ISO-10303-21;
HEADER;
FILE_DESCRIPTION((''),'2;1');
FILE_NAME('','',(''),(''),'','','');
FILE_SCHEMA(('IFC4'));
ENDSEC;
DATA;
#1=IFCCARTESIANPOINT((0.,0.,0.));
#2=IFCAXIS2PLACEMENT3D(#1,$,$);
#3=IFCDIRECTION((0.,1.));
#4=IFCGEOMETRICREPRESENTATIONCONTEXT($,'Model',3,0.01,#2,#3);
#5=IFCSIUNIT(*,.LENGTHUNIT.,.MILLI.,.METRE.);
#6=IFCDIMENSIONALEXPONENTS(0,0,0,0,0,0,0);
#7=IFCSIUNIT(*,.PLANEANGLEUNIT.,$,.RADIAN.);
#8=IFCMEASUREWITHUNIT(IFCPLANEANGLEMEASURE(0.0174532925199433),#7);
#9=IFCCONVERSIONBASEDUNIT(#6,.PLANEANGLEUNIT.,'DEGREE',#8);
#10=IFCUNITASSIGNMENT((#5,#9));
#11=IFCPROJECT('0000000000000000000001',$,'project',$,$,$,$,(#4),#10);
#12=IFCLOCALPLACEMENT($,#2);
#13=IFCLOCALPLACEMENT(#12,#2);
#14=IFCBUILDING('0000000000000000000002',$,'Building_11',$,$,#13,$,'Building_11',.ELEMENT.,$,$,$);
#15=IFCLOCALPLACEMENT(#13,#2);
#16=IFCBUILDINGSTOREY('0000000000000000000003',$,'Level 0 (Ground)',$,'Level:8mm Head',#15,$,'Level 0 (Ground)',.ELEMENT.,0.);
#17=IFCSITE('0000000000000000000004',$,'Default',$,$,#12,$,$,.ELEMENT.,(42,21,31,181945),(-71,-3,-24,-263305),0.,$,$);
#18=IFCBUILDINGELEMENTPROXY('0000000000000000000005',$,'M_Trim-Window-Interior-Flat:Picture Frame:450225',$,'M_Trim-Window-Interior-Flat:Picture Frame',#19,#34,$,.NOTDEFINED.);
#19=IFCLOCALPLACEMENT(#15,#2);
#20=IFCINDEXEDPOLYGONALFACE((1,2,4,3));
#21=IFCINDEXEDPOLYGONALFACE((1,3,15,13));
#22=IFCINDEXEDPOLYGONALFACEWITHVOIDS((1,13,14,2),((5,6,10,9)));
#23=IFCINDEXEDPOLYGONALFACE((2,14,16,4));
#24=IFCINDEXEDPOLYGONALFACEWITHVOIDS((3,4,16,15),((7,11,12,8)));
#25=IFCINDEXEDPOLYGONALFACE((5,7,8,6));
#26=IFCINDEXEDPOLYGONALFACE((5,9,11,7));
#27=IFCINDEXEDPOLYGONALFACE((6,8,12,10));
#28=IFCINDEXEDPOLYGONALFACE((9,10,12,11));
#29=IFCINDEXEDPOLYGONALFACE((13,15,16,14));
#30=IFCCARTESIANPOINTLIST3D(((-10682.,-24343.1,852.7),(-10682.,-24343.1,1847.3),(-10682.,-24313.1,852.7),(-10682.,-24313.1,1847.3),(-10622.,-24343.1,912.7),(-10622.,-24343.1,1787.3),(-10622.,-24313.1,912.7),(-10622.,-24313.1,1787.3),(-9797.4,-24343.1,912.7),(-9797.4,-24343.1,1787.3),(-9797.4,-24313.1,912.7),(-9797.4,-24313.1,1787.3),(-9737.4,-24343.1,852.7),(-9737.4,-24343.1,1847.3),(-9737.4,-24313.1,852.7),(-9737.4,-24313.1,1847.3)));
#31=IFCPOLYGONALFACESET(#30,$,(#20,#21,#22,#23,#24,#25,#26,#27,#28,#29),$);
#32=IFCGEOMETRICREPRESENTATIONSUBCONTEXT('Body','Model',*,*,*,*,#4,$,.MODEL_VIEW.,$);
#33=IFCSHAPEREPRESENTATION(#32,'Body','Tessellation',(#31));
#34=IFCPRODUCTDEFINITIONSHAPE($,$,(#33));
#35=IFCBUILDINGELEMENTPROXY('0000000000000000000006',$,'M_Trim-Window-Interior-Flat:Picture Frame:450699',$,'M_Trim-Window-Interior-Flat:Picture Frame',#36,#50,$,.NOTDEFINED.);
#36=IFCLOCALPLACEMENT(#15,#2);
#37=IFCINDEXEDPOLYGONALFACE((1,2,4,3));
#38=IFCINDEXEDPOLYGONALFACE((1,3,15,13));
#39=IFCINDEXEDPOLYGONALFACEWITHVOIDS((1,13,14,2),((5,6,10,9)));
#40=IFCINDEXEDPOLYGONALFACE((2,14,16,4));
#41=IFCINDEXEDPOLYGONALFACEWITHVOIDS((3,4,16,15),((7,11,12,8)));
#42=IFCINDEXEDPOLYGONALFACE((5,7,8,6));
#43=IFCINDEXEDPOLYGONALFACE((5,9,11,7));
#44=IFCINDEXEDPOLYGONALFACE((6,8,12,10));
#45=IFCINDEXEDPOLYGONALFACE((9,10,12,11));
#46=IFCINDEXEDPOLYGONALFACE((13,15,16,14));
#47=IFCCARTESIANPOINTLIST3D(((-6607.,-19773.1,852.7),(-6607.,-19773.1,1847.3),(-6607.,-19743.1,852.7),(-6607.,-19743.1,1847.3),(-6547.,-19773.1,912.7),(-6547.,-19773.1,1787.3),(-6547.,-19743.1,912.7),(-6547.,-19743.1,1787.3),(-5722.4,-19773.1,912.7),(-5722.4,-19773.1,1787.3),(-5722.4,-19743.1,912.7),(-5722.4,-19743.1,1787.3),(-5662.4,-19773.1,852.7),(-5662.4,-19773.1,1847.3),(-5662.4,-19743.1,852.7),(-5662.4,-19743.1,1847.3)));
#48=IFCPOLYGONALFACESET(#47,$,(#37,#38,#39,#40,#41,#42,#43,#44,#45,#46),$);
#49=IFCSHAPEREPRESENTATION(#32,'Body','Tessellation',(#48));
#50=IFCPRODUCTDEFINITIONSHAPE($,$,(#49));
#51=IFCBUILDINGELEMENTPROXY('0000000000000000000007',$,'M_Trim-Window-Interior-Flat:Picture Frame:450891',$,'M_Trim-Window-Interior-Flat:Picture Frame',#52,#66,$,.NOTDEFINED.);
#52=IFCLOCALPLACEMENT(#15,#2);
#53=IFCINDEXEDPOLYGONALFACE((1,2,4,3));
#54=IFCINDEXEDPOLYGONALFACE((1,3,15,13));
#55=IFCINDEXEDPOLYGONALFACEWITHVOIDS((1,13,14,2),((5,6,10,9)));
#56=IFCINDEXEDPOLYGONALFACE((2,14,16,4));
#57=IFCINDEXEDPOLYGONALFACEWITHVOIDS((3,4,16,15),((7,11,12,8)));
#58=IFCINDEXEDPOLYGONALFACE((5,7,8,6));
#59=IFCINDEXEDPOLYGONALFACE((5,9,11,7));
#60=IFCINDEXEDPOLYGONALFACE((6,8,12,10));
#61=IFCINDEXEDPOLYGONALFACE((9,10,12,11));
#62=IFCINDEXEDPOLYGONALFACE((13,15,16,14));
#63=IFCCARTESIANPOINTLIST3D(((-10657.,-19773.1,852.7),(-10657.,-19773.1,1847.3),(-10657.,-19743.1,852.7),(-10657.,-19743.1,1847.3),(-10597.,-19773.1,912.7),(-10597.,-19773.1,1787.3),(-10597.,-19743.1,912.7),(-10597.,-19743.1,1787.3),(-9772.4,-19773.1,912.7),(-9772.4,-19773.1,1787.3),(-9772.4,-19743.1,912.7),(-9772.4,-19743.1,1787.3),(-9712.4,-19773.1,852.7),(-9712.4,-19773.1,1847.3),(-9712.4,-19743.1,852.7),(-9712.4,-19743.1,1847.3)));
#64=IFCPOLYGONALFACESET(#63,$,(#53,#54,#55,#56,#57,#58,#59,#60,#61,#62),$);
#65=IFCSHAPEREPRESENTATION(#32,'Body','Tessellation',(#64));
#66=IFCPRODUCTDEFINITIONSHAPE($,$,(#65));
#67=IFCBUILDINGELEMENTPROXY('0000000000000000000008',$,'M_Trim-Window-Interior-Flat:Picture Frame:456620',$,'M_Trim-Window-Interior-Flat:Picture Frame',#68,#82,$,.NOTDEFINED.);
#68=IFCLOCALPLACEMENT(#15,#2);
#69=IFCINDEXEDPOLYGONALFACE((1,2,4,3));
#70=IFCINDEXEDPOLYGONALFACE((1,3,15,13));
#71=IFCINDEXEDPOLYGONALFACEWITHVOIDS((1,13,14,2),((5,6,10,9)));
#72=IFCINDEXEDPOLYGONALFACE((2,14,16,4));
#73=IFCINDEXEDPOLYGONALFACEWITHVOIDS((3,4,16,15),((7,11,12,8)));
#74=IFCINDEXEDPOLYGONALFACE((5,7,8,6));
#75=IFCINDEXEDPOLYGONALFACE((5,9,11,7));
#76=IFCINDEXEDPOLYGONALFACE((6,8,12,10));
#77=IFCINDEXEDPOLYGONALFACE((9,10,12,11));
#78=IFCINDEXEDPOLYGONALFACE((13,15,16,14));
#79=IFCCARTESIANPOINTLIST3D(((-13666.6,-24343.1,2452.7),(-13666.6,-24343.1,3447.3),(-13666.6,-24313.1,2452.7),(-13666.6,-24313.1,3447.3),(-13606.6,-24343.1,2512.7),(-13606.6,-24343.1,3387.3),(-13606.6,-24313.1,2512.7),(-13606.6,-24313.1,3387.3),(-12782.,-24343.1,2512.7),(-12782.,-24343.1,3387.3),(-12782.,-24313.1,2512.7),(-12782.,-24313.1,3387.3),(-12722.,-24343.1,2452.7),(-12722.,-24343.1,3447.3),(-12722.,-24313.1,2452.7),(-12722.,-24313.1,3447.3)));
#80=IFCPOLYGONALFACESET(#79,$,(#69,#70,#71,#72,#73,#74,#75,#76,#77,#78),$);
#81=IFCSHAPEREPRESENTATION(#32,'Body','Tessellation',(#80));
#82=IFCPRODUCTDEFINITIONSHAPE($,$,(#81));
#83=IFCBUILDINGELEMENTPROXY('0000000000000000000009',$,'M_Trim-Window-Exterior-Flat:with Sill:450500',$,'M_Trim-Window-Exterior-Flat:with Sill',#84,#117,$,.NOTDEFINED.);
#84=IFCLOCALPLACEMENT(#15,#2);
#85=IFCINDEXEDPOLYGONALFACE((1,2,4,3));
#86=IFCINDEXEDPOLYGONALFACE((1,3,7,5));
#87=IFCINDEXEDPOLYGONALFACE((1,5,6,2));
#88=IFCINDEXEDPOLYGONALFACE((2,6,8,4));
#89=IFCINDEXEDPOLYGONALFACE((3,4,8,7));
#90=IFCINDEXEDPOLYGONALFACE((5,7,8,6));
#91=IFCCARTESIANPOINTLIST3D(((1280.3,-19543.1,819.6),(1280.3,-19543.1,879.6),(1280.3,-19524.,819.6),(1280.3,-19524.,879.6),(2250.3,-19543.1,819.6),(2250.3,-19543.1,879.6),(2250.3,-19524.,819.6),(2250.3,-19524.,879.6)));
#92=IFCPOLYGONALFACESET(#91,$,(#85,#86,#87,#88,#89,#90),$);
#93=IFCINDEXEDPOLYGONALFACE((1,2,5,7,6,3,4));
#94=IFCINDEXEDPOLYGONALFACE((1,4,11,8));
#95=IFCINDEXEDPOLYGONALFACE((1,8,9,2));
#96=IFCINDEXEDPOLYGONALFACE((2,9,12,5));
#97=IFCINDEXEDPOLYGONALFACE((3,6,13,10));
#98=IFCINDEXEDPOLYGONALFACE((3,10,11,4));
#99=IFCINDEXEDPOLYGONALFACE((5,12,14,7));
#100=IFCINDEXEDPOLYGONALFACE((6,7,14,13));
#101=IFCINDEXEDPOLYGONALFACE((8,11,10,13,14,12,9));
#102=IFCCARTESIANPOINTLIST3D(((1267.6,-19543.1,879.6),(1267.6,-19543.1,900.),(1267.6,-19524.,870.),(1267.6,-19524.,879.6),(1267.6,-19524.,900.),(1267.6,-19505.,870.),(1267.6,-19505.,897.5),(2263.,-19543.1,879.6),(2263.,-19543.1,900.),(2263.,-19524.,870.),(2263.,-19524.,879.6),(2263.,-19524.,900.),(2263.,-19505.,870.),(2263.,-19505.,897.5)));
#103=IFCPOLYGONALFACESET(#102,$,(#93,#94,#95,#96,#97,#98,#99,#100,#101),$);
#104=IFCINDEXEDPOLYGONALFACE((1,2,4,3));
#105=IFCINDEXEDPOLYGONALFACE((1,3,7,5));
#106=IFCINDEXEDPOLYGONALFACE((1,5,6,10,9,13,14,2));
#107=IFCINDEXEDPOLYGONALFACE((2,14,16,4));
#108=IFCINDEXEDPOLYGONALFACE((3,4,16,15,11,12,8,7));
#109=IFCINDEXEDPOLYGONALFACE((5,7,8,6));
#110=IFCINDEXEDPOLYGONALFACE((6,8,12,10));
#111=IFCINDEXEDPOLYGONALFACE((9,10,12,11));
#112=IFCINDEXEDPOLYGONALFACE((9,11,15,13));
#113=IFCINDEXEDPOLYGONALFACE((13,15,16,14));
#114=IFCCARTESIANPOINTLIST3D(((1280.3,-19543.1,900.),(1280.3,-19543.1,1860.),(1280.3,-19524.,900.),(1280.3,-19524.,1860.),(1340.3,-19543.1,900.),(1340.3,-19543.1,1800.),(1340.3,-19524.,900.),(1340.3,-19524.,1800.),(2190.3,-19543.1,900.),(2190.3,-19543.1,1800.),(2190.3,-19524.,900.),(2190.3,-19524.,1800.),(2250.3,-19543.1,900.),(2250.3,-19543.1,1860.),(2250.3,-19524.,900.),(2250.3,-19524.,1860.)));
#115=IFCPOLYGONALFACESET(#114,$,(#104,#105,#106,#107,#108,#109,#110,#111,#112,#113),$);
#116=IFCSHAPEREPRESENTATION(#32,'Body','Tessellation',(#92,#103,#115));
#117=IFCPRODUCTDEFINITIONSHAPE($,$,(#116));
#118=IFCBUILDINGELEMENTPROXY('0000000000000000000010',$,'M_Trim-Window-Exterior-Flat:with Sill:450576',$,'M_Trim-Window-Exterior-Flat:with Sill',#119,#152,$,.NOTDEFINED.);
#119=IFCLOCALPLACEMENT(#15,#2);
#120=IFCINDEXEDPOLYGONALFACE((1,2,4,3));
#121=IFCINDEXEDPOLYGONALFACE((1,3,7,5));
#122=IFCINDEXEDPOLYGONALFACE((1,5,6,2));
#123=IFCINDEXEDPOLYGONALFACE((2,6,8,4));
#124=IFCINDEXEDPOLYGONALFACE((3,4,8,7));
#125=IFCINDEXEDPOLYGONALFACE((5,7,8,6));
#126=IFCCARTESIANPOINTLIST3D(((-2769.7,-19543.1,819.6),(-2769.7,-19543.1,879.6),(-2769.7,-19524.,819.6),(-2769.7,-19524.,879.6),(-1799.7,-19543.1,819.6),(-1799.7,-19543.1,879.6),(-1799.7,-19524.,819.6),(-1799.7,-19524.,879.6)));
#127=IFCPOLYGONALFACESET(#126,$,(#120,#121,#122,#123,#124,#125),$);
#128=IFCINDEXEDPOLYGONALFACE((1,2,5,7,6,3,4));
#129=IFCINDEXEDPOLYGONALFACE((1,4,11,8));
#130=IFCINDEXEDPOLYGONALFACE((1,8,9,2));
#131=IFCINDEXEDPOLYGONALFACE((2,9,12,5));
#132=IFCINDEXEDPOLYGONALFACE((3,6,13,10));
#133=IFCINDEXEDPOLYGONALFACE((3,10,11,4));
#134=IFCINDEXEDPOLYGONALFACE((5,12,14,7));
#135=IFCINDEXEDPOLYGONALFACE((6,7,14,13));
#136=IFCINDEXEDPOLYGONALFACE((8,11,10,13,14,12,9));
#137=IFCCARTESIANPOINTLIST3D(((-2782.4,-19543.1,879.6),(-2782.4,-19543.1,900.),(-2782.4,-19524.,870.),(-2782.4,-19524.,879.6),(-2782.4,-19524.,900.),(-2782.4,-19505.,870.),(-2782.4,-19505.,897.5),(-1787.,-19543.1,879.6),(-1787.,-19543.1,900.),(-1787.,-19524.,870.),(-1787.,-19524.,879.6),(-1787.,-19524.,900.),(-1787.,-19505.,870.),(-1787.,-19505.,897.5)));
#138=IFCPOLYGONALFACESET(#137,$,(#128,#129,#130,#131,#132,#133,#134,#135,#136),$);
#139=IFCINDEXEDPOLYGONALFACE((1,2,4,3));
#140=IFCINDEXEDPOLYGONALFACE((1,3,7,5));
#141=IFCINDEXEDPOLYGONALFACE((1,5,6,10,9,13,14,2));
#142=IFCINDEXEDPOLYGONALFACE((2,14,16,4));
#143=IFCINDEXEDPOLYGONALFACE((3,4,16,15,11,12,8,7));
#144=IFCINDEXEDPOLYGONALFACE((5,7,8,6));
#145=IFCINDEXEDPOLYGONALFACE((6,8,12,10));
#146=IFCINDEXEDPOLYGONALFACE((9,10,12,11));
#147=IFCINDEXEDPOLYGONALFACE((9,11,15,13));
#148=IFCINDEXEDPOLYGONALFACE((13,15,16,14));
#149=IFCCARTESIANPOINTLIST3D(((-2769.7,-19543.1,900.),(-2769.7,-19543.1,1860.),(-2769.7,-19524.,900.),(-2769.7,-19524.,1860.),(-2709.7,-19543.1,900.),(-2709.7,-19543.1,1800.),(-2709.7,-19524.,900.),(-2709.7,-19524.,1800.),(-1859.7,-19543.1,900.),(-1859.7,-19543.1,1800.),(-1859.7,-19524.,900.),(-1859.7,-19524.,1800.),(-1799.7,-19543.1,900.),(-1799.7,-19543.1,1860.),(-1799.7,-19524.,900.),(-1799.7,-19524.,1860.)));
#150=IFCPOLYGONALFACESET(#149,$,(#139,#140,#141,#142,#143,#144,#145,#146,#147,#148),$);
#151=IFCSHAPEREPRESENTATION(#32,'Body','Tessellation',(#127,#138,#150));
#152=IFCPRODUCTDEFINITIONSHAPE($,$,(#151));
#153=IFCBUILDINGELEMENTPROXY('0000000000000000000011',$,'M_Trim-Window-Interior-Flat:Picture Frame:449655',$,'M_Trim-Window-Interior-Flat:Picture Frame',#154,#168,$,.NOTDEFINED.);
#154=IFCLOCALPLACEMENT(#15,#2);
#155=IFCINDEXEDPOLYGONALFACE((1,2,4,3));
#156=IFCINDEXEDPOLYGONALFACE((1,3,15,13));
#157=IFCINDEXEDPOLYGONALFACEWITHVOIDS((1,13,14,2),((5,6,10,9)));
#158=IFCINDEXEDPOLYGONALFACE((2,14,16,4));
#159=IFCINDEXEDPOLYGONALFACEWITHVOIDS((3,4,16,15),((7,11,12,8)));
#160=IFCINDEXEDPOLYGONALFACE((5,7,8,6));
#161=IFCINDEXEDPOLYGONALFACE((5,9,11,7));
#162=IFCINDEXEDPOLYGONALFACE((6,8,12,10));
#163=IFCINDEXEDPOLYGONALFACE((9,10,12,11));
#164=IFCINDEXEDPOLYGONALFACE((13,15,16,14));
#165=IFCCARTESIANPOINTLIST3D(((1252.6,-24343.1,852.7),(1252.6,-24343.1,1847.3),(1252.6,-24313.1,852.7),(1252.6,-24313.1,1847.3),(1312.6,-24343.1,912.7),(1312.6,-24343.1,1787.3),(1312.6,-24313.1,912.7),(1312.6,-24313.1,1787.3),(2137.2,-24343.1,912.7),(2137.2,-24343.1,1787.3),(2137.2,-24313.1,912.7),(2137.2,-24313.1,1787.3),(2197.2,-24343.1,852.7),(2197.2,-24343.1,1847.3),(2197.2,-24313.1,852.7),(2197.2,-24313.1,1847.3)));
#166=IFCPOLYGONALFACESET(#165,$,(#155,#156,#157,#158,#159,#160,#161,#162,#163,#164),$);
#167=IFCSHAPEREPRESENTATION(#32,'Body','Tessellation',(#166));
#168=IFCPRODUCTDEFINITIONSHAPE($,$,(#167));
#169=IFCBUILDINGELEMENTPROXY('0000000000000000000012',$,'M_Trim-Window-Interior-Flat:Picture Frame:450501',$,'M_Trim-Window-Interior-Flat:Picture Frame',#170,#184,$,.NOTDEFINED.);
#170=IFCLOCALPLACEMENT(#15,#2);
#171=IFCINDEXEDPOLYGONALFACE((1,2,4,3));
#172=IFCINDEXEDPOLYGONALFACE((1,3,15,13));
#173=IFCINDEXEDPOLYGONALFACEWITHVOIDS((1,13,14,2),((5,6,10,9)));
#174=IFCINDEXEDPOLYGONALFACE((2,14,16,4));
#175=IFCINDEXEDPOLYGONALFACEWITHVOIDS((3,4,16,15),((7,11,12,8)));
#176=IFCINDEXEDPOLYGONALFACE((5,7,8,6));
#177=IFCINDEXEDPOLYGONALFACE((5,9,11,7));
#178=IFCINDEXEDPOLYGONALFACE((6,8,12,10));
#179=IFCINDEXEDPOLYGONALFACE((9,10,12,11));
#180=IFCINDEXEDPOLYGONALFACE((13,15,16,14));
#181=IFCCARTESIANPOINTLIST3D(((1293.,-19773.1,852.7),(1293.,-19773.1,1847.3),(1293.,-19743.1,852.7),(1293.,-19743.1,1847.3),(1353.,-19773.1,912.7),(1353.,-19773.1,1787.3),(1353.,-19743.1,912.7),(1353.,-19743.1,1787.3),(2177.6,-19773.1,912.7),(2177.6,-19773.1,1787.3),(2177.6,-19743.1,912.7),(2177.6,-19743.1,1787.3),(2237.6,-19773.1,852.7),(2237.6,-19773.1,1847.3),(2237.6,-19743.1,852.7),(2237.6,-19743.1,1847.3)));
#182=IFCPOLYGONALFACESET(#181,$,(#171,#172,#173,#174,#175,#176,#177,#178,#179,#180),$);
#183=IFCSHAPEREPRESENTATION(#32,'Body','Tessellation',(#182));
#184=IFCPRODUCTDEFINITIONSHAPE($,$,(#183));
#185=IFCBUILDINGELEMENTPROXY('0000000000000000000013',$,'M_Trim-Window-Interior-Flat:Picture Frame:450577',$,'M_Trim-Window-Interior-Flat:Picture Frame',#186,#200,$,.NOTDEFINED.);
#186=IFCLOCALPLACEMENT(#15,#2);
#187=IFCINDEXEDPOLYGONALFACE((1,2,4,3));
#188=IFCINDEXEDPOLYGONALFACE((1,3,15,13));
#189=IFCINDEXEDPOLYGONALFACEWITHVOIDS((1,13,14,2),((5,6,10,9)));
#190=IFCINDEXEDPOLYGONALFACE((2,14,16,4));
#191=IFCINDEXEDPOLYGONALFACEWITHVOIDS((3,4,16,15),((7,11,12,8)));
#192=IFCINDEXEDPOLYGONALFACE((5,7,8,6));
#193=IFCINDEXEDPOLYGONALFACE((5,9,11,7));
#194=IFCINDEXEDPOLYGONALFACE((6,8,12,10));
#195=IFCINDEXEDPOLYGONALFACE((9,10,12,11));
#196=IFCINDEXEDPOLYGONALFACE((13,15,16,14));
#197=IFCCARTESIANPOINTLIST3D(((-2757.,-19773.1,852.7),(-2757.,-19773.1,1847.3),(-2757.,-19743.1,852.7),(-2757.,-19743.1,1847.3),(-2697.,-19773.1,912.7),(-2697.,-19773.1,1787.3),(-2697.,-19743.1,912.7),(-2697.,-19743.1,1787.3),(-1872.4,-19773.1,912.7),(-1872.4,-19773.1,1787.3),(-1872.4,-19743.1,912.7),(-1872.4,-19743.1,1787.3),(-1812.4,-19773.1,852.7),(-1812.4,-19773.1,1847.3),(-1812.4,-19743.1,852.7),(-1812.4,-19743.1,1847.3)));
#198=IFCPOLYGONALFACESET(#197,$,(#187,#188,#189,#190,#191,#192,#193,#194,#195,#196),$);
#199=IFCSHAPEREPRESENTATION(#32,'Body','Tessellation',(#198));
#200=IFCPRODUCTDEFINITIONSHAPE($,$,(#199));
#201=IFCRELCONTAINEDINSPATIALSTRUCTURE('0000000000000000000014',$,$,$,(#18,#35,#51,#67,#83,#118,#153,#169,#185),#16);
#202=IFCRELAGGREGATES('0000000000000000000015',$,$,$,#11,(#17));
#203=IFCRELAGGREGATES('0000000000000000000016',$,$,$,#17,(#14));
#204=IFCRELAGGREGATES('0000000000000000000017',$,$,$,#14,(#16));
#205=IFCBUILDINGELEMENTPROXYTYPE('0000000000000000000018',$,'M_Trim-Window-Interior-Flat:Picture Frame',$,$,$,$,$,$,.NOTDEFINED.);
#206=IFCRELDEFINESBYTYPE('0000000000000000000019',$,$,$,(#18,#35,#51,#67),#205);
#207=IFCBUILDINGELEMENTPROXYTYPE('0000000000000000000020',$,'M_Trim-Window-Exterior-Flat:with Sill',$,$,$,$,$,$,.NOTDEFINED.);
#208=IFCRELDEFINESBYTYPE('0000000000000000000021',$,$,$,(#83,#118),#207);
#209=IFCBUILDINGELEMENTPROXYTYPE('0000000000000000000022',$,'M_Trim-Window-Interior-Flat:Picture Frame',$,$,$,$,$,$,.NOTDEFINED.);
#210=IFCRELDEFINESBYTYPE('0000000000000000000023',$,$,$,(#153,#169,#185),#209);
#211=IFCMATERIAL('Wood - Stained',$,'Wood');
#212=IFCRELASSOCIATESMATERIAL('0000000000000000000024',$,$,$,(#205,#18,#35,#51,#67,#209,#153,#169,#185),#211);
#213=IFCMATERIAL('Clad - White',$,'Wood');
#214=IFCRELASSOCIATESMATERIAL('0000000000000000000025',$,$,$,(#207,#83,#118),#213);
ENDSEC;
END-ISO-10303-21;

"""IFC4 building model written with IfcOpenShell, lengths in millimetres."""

from ifc_helpers import new_model, entity, si_unit, converted_unit, direction, frame, origin, place, context, subcontext, project, spatial, indexed_curve, outline, extrude, source, transform, mapped, material, type_object, type_shapes, element, save


model = new_model("IFC4")

# Units and contexts
model_context = context("Model", 3, precision=0.01, world=origin(), true_north=direction((0.0, 1.0)))
body_context = subcontext(model_context, "Body", "Model", "MODEL_VIEW")
ifc_project = project(units=[si_unit("LENGTHUNIT", "METRE", prefix="MILLI"), converted_unit("PLANEANGLEUNIT", "DEGREE", entity("IfcPlaneAngleMeasure", 0.0174532925199433), si_unit("PLANEANGLEUNIT", "RADIAN"), dimensions=[0, 0, 0, 0, 0, 0, 0])], contexts=[model_context])

# Site, building, storey
site_placement = place(None, origin())
site = spatial("IfcSite", under=ifc_project, at=site_placement, Name="Default", CompositionType="ELEMENT", RefLatitude=(42, 21, 31, 181945), RefLongitude=(-71, -3, -24, -263305), RefElevation=0.0)
building_placement = place(site_placement, origin())
building = spatial("IfcBuilding", under=site, at=building_placement, Name="Building_11", LongName="Building_11", CompositionType="ELEMENT")
storey_placement = place(building_placement, origin())
storey = spatial("IfcBuildingStorey", under=building, at=storey_placement, Name="Level 0 (Ground)", ObjectType="Level:8mm Head", LongName="Level 0 (Ground)", CompositionType="ELEMENT", Elevation=0.0)

# Building element proxies
ifc_material_1 = material(Name="Clad - White", Category="Wood")
ifc_material_2 = material(Name="Wood - Stained", Category="Wood")
building_element_proxy_type_1 = type_object("IfcBuildingElementProxyType", Name="M_Trim-Window-Interior-Flat:Picture Frame", PredefinedType="NOTDEFINED", material=ifc_material_2)
shared_shape_1 = source(origin(), body_context, "Body", "SweptSolid", [
    extrude(outline(indexed_curve([(-472.3, -497.3), (472.3, -497.3), (472.3, 497.3), (-472.3, 497.3), (-472.3, -497.3)], self_intersect=False), holes=[indexed_curve([(-412.3, -437.3), (-412.3, 437.3), (412.3, 437.3), (412.3, -437.3), (-412.3, -437.3)], self_intersect=False)]), frame((0.0, -450.0, 0.0), z_axis=(0.0, 0.0, 1.0), x_axis=(-1.0, 0.0, 0.0)), (0.0, 0.0, 1.0), 30.0),
])
type_shapes(building_element_proxy_type_1, [shared_shape_1])
for number, where, z_axis, x_axis, name in (
    (1, (-10209.7, -24343.1, 1800.0), (0.0, 1.0, 0.0), (-1.0, 0.0, 0.0), "M_Trim-Window-Interior-Flat:Picture Frame:450225"),
    (2, (-6134.7, -19743.1, 1800.0), (0.0, -1.0, 0.0), (1.0, 0.0, 0.0), "M_Trim-Window-Interior-Flat:Picture Frame:450699"),
    (3, (-10184.7, -19743.1, 1800.0), (0.0, -1.0, 0.0), (1.0, 0.0, 0.0), "M_Trim-Window-Interior-Flat:Picture Frame:450891"),
    (4, (-13194.3, -24343.1, 3400.0), (0.0, 1.0, 0.0), (-1.0, 0.0, 0.0), "M_Trim-Window-Interior-Flat:Picture Frame:456620"),
):
    element("IfcBuildingElementProxy", number, at=place(storey_placement, frame(where, z_axis=z_axis, x_axis=x_axis)), inside=storey, type_object=building_element_proxy_type_1, material=ifc_material_2, Name=name, ObjectType="M_Trim-Window-Interior-Flat:Picture Frame", PredefinedType="NOTDEFINED", context=body_context, shape_type="MappedRepresentation", body=[
        mapped(shared_shape_1, transform((0.0, 0.0, 0.0), scale=1.0)),
    ])
building_element_proxy_type_2 = type_object("IfcBuildingElementProxyType", Name="M_Trim-Window-Exterior-Flat:with Sill", PredefinedType="NOTDEFINED", material=ifc_material_1)
shared_shape_2 = source(origin(), body_context, "Body", "SweptSolid", [
    extrude(outline(indexed_curve([(-30.0, -485.0), (30.0, -485.0), (30.0, 485.0), (-30.0, 485.0), (-30.0, -485.0)], self_intersect=False)), frame((0.0, 950.4, 0.0), z_axis=(0.0, 0.0, 1.0), x_axis=(0.0, 1.0, 0.0)), (0.0, 0.0, 1.0), 19.1),
    extrude(outline(indexed_curve([(-15.2, -19.0), (12.3, -19.0), (14.8, 0.0), (14.8, 19.0), (-5.7, 19.0), (-5.7, 0.0), (-15.2, 0.0), (-15.2, -19.0)], self_intersect=False)), frame((-497.7, 914.8, 19.0), z_axis=(1.0, 0.0, 0.0), x_axis=(0.0, -1.0, 0.0)), (0.0, 0.0, 1.0), 995.4),
    extrude(outline(indexed_curve([(-485.0, -495.0), (485.0, -495.0), (485.0, 465.0), (425.0, 465.0), (425.0, -435.0), (-425.0, -435.0), (-425.0, 465.0), (-485.0, 465.0), (-485.0, -495.0)], self_intersect=False)), frame((0.0, 435.0, 0.0)), (0.0, 0.0, 1.0), 19.1),
])
type_shapes(building_element_proxy_type_2, [shared_shape_2])
for number, where, z_axis, x_axis, name in (
    (5, (1765.3, -19543.1, 1800.0), (0.0, 1.0, 0.0), (1.0, 0.0, 0.0), "M_Trim-Window-Exterior-Flat:with Sill:450500"),
    (6, (-2284.7, -19543.1, 1800.0), (0.0, 1.0, 0.0), (1.0, 0.0, 0.0), "M_Trim-Window-Exterior-Flat:with Sill:450576"),
):
    element("IfcBuildingElementProxy", number, at=place(storey_placement, frame(where, z_axis=z_axis, x_axis=x_axis)), inside=storey, type_object=building_element_proxy_type_2, material=ifc_material_1, Name=name, ObjectType="M_Trim-Window-Exterior-Flat:with Sill", PredefinedType="NOTDEFINED", context=body_context, shape_type="MappedRepresentation", body=[
        mapped(shared_shape_2, transform((0.0, 0.0, 0.0), scale=1.0)),
    ])
building_element_proxy_type_3 = type_object("IfcBuildingElementProxyType", Name="M_Trim-Window-Interior-Flat:Picture Frame", PredefinedType="NOTDEFINED", material=ifc_material_2)
shared_shape_3 = source(origin(), body_context, "Body", "SweptSolid", [
    extrude(outline(indexed_curve([(-497.3, -472.3), (497.3, -472.3), (497.3, 472.3), (-497.3, 472.3), (-497.3, -472.3)], self_intersect=False), holes=[indexed_curve([(-437.3, -412.3), (-437.3, 412.3), (437.3, 412.3), (437.3, -412.3), (-437.3, -412.3)], self_intersect=False)]), frame((0.0, 450.0, 0.0), z_axis=(0.0, 0.0, 1.0), x_axis=(0.0, 1.0, 0.0)), (0.0, 0.0, 1.0), 30.0),
])
type_shapes(building_element_proxy_type_3, [shared_shape_3])
for number, where, z_axis, x_axis, name in (
    (7, (1724.9, -24343.1, 1800.0), (0.0, 1.0, 0.0), (1.0, 0.0, 0.0), "M_Trim-Window-Interior-Flat:Picture Frame:449655"),
    (8, (1765.3, -19743.1, 1800.0), (0.0, -1.0, 0.0), (-1.0, 0.0, 0.0), "M_Trim-Window-Interior-Flat:Picture Frame:450501"),
    (9, (-2284.7, -19743.1, 1800.0), (0.0, -1.0, 0.0), (-1.0, 0.0, 0.0), "M_Trim-Window-Interior-Flat:Picture Frame:450577"),
):
    element("IfcBuildingElementProxy", number, at=place(storey_placement, frame(where, z_axis=z_axis, x_axis=x_axis)), inside=storey, type_object=building_element_proxy_type_3, material=ifc_material_2, Name=name, ObjectType="M_Trim-Window-Interior-Flat:Picture Frame", PredefinedType="NOTDEFINED", context=body_context, shape_type="MappedRepresentation", body=[
        mapped(shared_shape_3, transform((0.0, 0.0, 0.0), scale=1.0)),
    ])

save(model, "model.ifc")
